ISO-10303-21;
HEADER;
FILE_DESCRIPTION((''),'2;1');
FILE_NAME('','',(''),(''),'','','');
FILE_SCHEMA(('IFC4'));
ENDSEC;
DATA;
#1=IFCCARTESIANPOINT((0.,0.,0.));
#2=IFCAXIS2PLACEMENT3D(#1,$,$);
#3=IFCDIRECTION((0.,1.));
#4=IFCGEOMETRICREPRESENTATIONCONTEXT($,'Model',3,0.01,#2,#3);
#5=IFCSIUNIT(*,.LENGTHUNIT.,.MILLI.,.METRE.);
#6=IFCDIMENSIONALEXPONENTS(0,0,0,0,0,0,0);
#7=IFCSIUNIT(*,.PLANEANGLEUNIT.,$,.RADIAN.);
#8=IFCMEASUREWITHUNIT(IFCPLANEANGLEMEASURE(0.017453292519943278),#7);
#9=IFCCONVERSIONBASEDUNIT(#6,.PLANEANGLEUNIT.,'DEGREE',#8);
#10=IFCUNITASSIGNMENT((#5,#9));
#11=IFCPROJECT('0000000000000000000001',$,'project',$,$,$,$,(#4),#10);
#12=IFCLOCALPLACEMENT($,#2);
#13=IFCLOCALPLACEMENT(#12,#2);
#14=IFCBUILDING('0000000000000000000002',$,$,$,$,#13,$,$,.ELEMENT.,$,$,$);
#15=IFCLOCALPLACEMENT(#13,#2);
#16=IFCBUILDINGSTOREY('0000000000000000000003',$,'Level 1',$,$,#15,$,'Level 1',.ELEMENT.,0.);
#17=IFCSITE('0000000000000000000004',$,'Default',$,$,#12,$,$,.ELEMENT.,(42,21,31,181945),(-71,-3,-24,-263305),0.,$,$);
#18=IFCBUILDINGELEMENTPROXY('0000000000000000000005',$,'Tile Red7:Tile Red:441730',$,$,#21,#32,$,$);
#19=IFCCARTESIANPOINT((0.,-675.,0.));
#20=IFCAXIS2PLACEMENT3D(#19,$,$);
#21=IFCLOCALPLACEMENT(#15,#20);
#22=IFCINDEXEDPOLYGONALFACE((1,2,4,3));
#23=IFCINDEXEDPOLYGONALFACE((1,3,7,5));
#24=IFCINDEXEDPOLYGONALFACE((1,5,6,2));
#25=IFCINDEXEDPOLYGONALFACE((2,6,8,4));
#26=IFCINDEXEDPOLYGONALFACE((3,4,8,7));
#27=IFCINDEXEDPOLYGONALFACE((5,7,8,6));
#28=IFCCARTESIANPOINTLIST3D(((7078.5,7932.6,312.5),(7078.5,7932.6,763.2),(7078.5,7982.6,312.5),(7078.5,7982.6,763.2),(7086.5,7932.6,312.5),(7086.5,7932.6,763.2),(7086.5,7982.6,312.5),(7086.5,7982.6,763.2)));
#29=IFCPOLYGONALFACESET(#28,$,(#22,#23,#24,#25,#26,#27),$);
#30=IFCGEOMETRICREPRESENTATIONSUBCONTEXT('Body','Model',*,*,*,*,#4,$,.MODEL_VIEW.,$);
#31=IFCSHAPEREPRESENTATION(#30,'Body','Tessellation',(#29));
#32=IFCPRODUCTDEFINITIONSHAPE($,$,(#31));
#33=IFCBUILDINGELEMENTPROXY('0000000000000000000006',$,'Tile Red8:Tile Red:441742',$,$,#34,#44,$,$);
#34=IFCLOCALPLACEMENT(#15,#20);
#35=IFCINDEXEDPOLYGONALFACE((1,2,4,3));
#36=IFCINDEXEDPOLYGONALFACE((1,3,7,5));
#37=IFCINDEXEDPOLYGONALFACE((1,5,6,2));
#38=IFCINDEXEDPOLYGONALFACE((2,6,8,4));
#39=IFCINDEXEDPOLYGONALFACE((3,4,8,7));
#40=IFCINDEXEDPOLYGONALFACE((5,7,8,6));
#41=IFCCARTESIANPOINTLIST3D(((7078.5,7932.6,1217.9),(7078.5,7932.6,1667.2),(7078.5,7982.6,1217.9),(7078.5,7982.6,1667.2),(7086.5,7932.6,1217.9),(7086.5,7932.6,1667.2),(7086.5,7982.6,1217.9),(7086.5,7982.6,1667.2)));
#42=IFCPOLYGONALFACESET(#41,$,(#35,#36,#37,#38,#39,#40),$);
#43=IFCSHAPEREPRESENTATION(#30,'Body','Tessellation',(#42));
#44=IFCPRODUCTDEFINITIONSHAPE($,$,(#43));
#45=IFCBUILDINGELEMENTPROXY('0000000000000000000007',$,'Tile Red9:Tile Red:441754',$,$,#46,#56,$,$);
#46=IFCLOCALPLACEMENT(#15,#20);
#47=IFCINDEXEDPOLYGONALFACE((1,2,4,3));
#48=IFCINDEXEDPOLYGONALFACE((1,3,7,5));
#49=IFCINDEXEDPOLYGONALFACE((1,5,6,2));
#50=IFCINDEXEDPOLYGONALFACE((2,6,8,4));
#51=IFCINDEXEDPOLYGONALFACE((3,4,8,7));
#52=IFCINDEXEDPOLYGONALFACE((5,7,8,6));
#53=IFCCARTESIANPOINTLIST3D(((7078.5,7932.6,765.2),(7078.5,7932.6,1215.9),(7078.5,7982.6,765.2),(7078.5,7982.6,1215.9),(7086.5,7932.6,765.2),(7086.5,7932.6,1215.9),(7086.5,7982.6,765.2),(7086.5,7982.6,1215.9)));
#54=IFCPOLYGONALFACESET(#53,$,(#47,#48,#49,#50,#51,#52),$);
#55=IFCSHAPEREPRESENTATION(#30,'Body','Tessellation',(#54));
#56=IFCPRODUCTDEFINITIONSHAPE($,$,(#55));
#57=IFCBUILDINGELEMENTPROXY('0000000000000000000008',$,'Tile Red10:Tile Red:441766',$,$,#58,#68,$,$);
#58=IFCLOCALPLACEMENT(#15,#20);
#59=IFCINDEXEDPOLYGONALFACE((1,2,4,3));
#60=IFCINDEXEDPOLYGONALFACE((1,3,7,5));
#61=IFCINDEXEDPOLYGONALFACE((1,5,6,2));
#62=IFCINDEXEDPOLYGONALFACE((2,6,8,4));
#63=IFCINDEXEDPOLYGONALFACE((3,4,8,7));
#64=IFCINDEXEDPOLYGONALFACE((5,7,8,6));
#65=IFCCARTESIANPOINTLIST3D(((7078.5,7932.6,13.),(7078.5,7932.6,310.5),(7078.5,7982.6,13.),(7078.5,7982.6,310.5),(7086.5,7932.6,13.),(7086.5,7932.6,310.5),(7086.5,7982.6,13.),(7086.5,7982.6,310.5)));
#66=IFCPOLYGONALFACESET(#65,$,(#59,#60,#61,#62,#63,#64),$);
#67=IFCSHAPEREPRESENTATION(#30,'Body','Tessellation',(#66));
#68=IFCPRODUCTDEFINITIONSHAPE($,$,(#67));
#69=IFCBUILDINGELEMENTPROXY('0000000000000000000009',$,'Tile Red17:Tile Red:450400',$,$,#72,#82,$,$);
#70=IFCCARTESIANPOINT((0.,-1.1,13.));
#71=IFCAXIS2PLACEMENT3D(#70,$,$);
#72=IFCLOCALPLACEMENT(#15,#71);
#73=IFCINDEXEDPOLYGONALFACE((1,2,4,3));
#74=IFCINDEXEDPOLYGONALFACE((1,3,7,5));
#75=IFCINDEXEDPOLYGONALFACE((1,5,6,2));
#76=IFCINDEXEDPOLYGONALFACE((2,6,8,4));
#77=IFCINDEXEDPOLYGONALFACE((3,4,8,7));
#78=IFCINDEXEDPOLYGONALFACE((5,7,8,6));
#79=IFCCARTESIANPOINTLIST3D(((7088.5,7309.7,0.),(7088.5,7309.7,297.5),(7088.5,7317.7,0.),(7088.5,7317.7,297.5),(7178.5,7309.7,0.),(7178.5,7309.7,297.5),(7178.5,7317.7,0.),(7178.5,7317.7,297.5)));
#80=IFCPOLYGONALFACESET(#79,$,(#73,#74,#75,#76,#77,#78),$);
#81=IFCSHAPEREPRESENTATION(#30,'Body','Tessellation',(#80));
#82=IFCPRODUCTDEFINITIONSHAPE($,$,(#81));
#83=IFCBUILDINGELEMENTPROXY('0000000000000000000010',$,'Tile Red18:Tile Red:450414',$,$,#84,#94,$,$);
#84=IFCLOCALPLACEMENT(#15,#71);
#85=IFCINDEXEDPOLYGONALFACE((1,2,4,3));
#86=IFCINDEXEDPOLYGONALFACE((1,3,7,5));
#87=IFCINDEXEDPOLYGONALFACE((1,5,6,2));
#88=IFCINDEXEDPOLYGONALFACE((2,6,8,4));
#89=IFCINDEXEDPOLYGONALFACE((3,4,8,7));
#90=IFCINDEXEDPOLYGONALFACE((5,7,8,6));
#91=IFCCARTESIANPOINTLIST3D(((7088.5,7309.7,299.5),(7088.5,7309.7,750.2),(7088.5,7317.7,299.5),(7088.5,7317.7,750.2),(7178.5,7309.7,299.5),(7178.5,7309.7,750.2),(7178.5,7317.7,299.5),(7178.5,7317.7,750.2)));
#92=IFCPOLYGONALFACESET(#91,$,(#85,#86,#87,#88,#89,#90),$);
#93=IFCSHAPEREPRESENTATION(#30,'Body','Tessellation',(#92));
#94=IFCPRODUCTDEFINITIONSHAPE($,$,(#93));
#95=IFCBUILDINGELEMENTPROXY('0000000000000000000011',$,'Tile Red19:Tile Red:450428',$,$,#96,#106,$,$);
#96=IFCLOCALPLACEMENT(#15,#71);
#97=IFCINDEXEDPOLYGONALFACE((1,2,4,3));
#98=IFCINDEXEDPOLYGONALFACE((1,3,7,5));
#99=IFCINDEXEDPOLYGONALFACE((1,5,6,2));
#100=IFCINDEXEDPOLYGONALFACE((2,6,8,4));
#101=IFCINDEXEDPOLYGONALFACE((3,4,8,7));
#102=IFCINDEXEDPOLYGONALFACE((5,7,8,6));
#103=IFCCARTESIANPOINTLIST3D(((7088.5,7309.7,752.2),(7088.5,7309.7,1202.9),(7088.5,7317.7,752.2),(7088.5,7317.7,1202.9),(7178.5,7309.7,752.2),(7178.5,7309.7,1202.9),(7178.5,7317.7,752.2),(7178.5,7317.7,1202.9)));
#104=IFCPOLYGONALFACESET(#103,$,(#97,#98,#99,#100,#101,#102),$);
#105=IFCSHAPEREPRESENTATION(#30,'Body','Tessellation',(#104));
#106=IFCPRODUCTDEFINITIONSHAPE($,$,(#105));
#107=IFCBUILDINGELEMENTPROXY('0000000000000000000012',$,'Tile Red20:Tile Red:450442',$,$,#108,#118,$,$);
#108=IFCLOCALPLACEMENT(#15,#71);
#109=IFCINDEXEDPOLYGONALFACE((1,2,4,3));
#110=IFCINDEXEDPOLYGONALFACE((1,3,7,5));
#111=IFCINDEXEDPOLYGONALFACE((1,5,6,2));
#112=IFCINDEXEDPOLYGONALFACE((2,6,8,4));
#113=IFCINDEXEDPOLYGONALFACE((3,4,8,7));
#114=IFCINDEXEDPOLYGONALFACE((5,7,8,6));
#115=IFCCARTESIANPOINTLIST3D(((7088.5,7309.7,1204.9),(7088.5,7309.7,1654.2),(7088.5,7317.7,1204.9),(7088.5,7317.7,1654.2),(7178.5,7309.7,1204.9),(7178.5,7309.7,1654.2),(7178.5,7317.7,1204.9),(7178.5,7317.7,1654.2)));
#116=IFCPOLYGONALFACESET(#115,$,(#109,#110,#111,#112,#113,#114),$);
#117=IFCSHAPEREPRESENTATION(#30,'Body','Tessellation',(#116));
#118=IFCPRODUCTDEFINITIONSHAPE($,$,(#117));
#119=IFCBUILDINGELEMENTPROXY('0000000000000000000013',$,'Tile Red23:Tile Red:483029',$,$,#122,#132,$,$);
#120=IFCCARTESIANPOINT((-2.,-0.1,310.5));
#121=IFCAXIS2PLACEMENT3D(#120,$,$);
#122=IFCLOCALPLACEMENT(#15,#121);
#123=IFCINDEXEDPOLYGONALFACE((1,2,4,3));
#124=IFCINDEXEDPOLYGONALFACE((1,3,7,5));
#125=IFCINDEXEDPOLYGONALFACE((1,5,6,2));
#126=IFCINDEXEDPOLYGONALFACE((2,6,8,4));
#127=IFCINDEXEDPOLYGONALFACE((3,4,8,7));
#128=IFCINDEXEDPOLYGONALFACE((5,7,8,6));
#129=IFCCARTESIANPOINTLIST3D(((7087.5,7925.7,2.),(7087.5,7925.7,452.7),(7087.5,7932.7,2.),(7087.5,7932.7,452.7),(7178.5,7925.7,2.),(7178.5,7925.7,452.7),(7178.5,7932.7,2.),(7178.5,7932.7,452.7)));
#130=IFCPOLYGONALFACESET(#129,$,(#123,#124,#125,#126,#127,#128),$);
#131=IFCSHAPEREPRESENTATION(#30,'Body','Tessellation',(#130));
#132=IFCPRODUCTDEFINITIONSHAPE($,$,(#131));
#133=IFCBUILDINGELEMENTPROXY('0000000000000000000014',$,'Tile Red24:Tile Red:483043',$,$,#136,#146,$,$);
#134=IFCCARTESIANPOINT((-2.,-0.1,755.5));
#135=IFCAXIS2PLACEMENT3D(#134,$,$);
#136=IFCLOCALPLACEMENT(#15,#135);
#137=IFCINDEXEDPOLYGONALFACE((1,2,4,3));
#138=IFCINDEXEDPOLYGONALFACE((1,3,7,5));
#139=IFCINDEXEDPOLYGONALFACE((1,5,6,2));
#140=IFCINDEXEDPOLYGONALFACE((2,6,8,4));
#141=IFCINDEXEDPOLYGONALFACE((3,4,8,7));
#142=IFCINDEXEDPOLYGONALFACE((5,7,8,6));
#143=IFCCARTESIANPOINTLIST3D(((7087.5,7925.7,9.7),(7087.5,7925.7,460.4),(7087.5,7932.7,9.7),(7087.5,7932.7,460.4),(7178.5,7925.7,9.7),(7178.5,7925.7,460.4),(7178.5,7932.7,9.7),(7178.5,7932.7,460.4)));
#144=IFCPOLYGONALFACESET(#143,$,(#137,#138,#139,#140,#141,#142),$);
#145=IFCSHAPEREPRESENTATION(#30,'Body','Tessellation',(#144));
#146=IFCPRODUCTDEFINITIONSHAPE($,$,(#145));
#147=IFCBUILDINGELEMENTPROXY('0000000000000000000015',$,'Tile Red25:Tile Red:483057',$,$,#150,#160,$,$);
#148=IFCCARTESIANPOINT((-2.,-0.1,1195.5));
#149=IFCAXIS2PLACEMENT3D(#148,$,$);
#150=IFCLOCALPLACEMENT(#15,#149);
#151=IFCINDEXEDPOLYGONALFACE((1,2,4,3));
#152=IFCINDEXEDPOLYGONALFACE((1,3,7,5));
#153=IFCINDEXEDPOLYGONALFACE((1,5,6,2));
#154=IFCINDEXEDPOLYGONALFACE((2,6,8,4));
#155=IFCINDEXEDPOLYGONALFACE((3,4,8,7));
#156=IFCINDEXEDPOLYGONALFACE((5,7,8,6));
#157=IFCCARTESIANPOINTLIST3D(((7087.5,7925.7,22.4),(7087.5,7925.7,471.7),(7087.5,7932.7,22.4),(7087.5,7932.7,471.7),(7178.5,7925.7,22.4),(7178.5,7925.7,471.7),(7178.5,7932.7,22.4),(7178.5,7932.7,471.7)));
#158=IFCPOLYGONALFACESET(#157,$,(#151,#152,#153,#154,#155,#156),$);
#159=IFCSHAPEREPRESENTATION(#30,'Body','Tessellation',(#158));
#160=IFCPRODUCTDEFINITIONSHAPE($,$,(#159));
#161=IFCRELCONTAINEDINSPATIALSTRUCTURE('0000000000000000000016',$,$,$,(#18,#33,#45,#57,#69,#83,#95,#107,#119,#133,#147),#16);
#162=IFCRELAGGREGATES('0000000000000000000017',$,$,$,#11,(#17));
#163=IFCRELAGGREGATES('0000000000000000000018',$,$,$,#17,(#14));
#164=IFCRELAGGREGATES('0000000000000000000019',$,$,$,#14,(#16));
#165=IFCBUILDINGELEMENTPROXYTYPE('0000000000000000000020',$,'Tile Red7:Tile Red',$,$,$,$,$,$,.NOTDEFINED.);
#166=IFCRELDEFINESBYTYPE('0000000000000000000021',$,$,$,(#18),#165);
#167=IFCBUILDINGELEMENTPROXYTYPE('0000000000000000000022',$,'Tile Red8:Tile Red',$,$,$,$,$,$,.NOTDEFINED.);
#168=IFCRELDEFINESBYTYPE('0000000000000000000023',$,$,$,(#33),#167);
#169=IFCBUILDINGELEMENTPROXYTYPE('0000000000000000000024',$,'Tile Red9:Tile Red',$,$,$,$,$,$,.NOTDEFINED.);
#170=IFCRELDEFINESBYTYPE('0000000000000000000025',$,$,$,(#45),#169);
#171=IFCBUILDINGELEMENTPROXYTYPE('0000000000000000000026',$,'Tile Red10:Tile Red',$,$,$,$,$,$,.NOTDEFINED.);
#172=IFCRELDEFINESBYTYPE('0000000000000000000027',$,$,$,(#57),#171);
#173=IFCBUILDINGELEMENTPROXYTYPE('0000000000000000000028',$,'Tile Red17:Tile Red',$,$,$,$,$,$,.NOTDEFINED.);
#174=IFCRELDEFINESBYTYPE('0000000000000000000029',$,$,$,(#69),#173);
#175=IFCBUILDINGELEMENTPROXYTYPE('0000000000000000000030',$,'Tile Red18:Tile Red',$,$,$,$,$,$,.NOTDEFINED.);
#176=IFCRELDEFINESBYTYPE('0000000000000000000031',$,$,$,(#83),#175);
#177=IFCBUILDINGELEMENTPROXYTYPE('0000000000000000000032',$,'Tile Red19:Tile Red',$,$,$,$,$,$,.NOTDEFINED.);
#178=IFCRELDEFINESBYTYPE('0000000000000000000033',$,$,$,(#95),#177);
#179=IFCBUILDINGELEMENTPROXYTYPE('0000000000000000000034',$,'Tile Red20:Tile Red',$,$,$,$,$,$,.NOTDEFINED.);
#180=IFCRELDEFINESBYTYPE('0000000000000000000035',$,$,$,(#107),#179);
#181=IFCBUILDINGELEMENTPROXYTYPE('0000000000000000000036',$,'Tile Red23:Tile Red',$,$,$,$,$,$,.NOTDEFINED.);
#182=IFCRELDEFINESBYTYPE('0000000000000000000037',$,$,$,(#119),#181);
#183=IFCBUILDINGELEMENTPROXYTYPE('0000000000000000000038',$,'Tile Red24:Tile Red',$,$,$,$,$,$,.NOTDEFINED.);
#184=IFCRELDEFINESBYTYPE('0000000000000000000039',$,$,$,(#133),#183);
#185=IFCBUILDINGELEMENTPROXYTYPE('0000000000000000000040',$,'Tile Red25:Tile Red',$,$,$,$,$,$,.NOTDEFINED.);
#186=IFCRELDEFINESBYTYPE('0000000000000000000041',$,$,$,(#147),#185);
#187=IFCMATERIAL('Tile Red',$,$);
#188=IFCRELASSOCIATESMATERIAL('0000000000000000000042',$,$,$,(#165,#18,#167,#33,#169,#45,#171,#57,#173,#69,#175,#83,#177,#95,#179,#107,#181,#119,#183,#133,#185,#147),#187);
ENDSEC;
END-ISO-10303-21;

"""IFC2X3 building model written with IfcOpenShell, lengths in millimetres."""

from ifc_helpers import new_model, entity, si_unit, converted_unit, direction, frame, frame_2d, origin, origin_2d_with_axis, place, context, subcontext, project, spatial, rectangle, extrude, source, transform, mapped, material, type_object, type_shapes, element, save


model = new_model("IFC2X3")

# Units and contexts
model_context = context("Model", 3, precision=0.01, world=origin(), true_north=direction((0.0, 1.0)))
body_context = subcontext(model_context, "Body", "Model", "MODEL_VIEW")
ifc_project = project(units=[si_unit("LENGTHUNIT", "METRE", prefix="MILLI"), converted_unit("PLANEANGLEUNIT", "DEGREE", entity("IfcPlaneAngleMeasure", 0.017453292519943278), si_unit("PLANEANGLEUNIT", "RADIAN"), dimensions=[0, 0, 0, 0, 0, 0, 0])], contexts=[model_context])

# Site, building, storey
site_placement = place(None, origin())
site = spatial("IfcSite", under=ifc_project, at=site_placement, Name="Default", CompositionType="ELEMENT", RefLatitude=(42, 21, 31, 181945), RefLongitude=(-71, -3, -24, -263305), RefElevation=0.0)
building_placement = place(site_placement, origin())
building = spatial("IfcBuilding", under=site, at=building_placement, CompositionType="ELEMENT")
storey_placement = place(building_placement, origin())
storey = spatial("IfcBuildingStorey", under=building, at=storey_placement, Name="Level 1", LongName="Level 1", CompositionType="ELEMENT", Elevation=0.0)

# Building element proxies
ifc_material_1 = material(Name="Tile Red")
building_element_proxy_type_1 = type_object("IfcBuildingElementProxyType", Name="Tile Red7:Tile Red", PredefinedType="NOTDEFINED", material=ifc_material_1)
shared_shape_1 = source(origin(), body_context, "Body", "SweptSolid", [
    extrude(rectangle(XDim=8.0, YDim=50.0, at=origin_2d_with_axis()), frame((7082.5, 7957.6, 312.5)), (0.0, 0.0, 1.0), 450.7),
])
type_shapes(building_element_proxy_type_1, [shared_shape_1])
proxy_1_placement = place(storey_placement, frame((0.0, -675.0, 0.0)))
element("IfcBuildingElementProxy", 1, at=proxy_1_placement, inside=storey, type_object=building_element_proxy_type_1, material=ifc_material_1, Name="Tile Red7:Tile Red:441730", context=body_context, shape_type="MappedRepresentation", body=[
    mapped(shared_shape_1, transform((0.0, 0.0, 0.0), scale=1.0)),
])
building_element_proxy_type_2 = type_object("IfcBuildingElementProxyType", Name="Tile Red8:Tile Red", PredefinedType="NOTDEFINED", material=ifc_material_1)
shared_shape_2 = source(origin(), body_context, "Body", "SweptSolid", [
    extrude(rectangle(XDim=8.0, YDim=50.0, at=origin_2d_with_axis()), frame((7082.5, 7957.6, 1217.9)), (0.0, 0.0, 1.0), 449.3),
])
type_shapes(building_element_proxy_type_2, [shared_shape_2])
proxy_2_placement = place(storey_placement, frame((0.0, -675.0, 0.0)))
element("IfcBuildingElementProxy", 2, at=proxy_2_placement, inside=storey, type_object=building_element_proxy_type_2, material=ifc_material_1, Name="Tile Red8:Tile Red:441742", context=body_context, shape_type="MappedRepresentation", body=[
    mapped(shared_shape_2, transform((0.0, 0.0, 0.0), scale=1.0)),
])
building_element_proxy_type_3 = type_object("IfcBuildingElementProxyType", Name="Tile Red9:Tile Red", PredefinedType="NOTDEFINED", material=ifc_material_1)
shared_shape_3 = source(origin(), body_context, "Body", "SweptSolid", [
    extrude(rectangle(XDim=8.0, YDim=50.0, at=origin_2d_with_axis()), frame((7082.5, 7957.6, 765.2)), (0.0, 0.0, 1.0), 450.7),
])
type_shapes(building_element_proxy_type_3, [shared_shape_3])
proxy_3_placement = place(storey_placement, frame((0.0, -675.0, 0.0)))
element("IfcBuildingElementProxy", 3, at=proxy_3_placement, inside=storey, type_object=building_element_proxy_type_3, material=ifc_material_1, Name="Tile Red9:Tile Red:441754", context=body_context, shape_type="MappedRepresentation", body=[
    mapped(shared_shape_3, transform((0.0, 0.0, 0.0), scale=1.0)),
])
building_element_proxy_type_4 = type_object("IfcBuildingElementProxyType", Name="Tile Red10:Tile Red", PredefinedType="NOTDEFINED", material=ifc_material_1)
shared_shape_4 = source(origin(), body_context, "Body", "SweptSolid", [
    extrude(rectangle(XDim=8.0, YDim=50.0, at=origin_2d_with_axis()), frame((7082.5, 7957.6, 13.0)), (0.0, 0.0, 1.0), 297.5),
])
type_shapes(building_element_proxy_type_4, [shared_shape_4])
proxy_4_placement = place(storey_placement, frame((0.0, -675.0, 0.0)))
element("IfcBuildingElementProxy", 4, at=proxy_4_placement, inside=storey, type_object=building_element_proxy_type_4, material=ifc_material_1, Name="Tile Red10:Tile Red:441766", context=body_context, shape_type="MappedRepresentation", body=[
    mapped(shared_shape_4, transform((0.0, 0.0, 0.0), scale=1.0)),
])
building_element_proxy_type_5 = type_object("IfcBuildingElementProxyType", Name="Tile Red17:Tile Red", PredefinedType="NOTDEFINED", material=ifc_material_1)
shared_shape_5 = source(origin(), body_context, "Body", "SweptSolid", [
    extrude(rectangle(XDim=8.0, YDim=90.0, at=frame_2d((0.0, 0.0), x_axis=(1.0, 0.0))), frame((7133.5, 7313.7, 0.0), z_axis=(0.0, 0.0, 1.0), x_axis=(0.0, -1.0, 0.0)), (0.0, 0.0, 1.0), 297.5),
])
type_shapes(building_element_proxy_type_5, [shared_shape_5])
proxy_5_placement = place(storey_placement, frame((0.0, -1.1, 13.0)))
element("IfcBuildingElementProxy", 5, at=proxy_5_placement, inside=storey, type_object=building_element_proxy_type_5, material=ifc_material_1, Name="Tile Red17:Tile Red:450400", context=body_context, shape_type="MappedRepresentation", body=[
    mapped(shared_shape_5, transform((0.0, 0.0, 0.0), scale=1.0)),
])
building_element_proxy_type_6 = type_object("IfcBuildingElementProxyType", Name="Tile Red18:Tile Red", PredefinedType="NOTDEFINED", material=ifc_material_1)
shared_shape_6 = source(origin(), body_context, "Body", "SweptSolid", [
    extrude(rectangle(XDim=8.0, YDim=90.0, at=frame_2d((0.0, 0.0), x_axis=(1.0, 0.0))), frame((7133.5, 7313.7, 299.5), z_axis=(0.0, 0.0, 1.0), x_axis=(0.0, -1.0, 0.0)), (0.0, 0.0, 1.0), 450.7),
])
type_shapes(building_element_proxy_type_6, [shared_shape_6])
proxy_6_placement = place(storey_placement, frame((0.0, -1.1, 13.0)))
element("IfcBuildingElementProxy", 6, at=proxy_6_placement, inside=storey, type_object=building_element_proxy_type_6, material=ifc_material_1, Name="Tile Red18:Tile Red:450414", context=body_context, shape_type="MappedRepresentation", body=[
    mapped(shared_shape_6, transform((0.0, 0.0, 0.0), scale=1.0)),
])
building_element_proxy_type_7 = type_object("IfcBuildingElementProxyType", Name="Tile Red19:Tile Red", PredefinedType="NOTDEFINED", material=ifc_material_1)
shared_shape_7 = source(origin(), body_context, "Body", "SweptSolid", [
    extrude(rectangle(XDim=8.0, YDim=90.0, at=frame_2d((0.0, 0.0), x_axis=(1.0, 0.0))), frame((7133.5, 7313.7, 752.2), z_axis=(0.0, 0.0, 1.0), x_axis=(0.0, -1.0, 0.0)), (0.0, 0.0, 1.0), 450.7),
])
type_shapes(building_element_proxy_type_7, [shared_shape_7])
proxy_7_placement = place(storey_placement, frame((0.0, -1.1, 13.0)))
element("IfcBuildingElementProxy", 7, at=proxy_7_placement, inside=storey, type_object=building_element_proxy_type_7, material=ifc_material_1, Name="Tile Red19:Tile Red:450428", context=body_context, shape_type="MappedRepresentation", body=[
    mapped(shared_shape_7, transform((0.0, 0.0, 0.0), scale=1.0)),
])
building_element_proxy_type_8 = type_object("IfcBuildingElementProxyType", Name="Tile Red20:Tile Red", PredefinedType="NOTDEFINED", material=ifc_material_1)
shared_shape_8 = source(origin(), body_context, "Body", "SweptSolid", [
    extrude(rectangle(XDim=8.0, YDim=90.0, at=frame_2d((0.0, 0.0), x_axis=(1.0, 0.0))), frame((7133.5, 7313.7, 1204.9), z_axis=(0.0, 0.0, 1.0), x_axis=(0.0, -1.0, 0.0)), (0.0, 0.0, 1.0), 449.3),
])
type_shapes(building_element_proxy_type_8, [shared_shape_8])
proxy_8_placement = place(storey_placement, frame((0.0, -1.1, 13.0)))
element("IfcBuildingElementProxy", 8, at=proxy_8_placement, inside=storey, type_object=building_element_proxy_type_8, material=ifc_material_1, Name="Tile Red20:Tile Red:450442", context=body_context, shape_type="MappedRepresentation", body=[
    mapped(shared_shape_8, transform((0.0, 0.0, 0.0), scale=1.0)),
])
building_element_proxy_type_9 = type_object("IfcBuildingElementProxyType", Name="Tile Red23:Tile Red", PredefinedType="NOTDEFINED", material=ifc_material_1)
shared_shape_9 = source(origin(), body_context, "Body", "SweptSolid", [
    extrude(rectangle(XDim=7.0, YDim=91.0, at=frame_2d((0.0, 0.0), x_axis=(1.0, 0.0))), frame((7133.0, 7929.2, 2.0), z_axis=(0.0, 0.0, 1.0), x_axis=(0.0, 1.0, 0.0)), (0.0, 0.0, 1.0), 450.7),
])
type_shapes(building_element_proxy_type_9, [shared_shape_9])
proxy_9_placement = place(storey_placement, frame((-2.0, -0.1, 310.5)))
element("IfcBuildingElementProxy", 9, at=proxy_9_placement, inside=storey, type_object=building_element_proxy_type_9, material=ifc_material_1, Name="Tile Red23:Tile Red:483029", context=body_context, shape_type="MappedRepresentation", body=[
    mapped(shared_shape_9, transform((0.0, 0.0, 0.0), scale=1.0)),
])
building_element_proxy_type_10 = type_object("IfcBuildingElementProxyType", Name="Tile Red24:Tile Red", PredefinedType="NOTDEFINED", material=ifc_material_1)
shared_shape_10 = source(origin(), body_context, "Body", "SweptSolid", [
    extrude(rectangle(XDim=7.0, YDim=91.0, at=frame_2d((0.0, 0.0), x_axis=(1.0, 0.0))), frame((7133.0, 7929.2, 9.7), z_axis=(0.0, 0.0, 1.0), x_axis=(0.0, 1.0, 0.0)), (0.0, 0.0, 1.0), 450.7),
])
type_shapes(building_element_proxy_type_10, [shared_shape_10])
proxy_10_placement = place(storey_placement, frame((-2.0, -0.1, 755.5)))
element("IfcBuildingElementProxy", 10, at=proxy_10_placement, inside=storey, type_object=building_element_proxy_type_10, material=ifc_material_1, Name="Tile Red24:Tile Red:483043", context=body_context, shape_type="MappedRepresentation", body=[
    mapped(shared_shape_10, transform((0.0, 0.0, 0.0), scale=1.0)),
])
building_element_proxy_type_11 = type_object("IfcBuildingElementProxyType", Name="Tile Red25:Tile Red", PredefinedType="NOTDEFINED", material=ifc_material_1)
shared_shape_11 = source(origin(), body_context, "Body", "SweptSolid", [
    extrude(rectangle(XDim=7.0, YDim=91.0, at=frame_2d((0.0, 0.0), x_axis=(1.0, 0.0))), frame((7133.0, 7929.2, 22.4), z_axis=(0.0, 0.0, 1.0), x_axis=(0.0, 1.0, 0.0)), (0.0, 0.0, 1.0), 449.3),
])
type_shapes(building_element_proxy_type_11, [shared_shape_11])
proxy_11_placement = place(storey_placement, frame((-2.0, -0.1, 1195.5)))
element("IfcBuildingElementProxy", 11, at=proxy_11_placement, inside=storey, type_object=building_element_proxy_type_11, material=ifc_material_1, Name="Tile Red25:Tile Red:483057", context=body_context, shape_type="MappedRepresentation", body=[
    mapped(shared_shape_11, transform((0.0, 0.0, 0.0), scale=1.0)),
])

save(model, "model.ifc")
